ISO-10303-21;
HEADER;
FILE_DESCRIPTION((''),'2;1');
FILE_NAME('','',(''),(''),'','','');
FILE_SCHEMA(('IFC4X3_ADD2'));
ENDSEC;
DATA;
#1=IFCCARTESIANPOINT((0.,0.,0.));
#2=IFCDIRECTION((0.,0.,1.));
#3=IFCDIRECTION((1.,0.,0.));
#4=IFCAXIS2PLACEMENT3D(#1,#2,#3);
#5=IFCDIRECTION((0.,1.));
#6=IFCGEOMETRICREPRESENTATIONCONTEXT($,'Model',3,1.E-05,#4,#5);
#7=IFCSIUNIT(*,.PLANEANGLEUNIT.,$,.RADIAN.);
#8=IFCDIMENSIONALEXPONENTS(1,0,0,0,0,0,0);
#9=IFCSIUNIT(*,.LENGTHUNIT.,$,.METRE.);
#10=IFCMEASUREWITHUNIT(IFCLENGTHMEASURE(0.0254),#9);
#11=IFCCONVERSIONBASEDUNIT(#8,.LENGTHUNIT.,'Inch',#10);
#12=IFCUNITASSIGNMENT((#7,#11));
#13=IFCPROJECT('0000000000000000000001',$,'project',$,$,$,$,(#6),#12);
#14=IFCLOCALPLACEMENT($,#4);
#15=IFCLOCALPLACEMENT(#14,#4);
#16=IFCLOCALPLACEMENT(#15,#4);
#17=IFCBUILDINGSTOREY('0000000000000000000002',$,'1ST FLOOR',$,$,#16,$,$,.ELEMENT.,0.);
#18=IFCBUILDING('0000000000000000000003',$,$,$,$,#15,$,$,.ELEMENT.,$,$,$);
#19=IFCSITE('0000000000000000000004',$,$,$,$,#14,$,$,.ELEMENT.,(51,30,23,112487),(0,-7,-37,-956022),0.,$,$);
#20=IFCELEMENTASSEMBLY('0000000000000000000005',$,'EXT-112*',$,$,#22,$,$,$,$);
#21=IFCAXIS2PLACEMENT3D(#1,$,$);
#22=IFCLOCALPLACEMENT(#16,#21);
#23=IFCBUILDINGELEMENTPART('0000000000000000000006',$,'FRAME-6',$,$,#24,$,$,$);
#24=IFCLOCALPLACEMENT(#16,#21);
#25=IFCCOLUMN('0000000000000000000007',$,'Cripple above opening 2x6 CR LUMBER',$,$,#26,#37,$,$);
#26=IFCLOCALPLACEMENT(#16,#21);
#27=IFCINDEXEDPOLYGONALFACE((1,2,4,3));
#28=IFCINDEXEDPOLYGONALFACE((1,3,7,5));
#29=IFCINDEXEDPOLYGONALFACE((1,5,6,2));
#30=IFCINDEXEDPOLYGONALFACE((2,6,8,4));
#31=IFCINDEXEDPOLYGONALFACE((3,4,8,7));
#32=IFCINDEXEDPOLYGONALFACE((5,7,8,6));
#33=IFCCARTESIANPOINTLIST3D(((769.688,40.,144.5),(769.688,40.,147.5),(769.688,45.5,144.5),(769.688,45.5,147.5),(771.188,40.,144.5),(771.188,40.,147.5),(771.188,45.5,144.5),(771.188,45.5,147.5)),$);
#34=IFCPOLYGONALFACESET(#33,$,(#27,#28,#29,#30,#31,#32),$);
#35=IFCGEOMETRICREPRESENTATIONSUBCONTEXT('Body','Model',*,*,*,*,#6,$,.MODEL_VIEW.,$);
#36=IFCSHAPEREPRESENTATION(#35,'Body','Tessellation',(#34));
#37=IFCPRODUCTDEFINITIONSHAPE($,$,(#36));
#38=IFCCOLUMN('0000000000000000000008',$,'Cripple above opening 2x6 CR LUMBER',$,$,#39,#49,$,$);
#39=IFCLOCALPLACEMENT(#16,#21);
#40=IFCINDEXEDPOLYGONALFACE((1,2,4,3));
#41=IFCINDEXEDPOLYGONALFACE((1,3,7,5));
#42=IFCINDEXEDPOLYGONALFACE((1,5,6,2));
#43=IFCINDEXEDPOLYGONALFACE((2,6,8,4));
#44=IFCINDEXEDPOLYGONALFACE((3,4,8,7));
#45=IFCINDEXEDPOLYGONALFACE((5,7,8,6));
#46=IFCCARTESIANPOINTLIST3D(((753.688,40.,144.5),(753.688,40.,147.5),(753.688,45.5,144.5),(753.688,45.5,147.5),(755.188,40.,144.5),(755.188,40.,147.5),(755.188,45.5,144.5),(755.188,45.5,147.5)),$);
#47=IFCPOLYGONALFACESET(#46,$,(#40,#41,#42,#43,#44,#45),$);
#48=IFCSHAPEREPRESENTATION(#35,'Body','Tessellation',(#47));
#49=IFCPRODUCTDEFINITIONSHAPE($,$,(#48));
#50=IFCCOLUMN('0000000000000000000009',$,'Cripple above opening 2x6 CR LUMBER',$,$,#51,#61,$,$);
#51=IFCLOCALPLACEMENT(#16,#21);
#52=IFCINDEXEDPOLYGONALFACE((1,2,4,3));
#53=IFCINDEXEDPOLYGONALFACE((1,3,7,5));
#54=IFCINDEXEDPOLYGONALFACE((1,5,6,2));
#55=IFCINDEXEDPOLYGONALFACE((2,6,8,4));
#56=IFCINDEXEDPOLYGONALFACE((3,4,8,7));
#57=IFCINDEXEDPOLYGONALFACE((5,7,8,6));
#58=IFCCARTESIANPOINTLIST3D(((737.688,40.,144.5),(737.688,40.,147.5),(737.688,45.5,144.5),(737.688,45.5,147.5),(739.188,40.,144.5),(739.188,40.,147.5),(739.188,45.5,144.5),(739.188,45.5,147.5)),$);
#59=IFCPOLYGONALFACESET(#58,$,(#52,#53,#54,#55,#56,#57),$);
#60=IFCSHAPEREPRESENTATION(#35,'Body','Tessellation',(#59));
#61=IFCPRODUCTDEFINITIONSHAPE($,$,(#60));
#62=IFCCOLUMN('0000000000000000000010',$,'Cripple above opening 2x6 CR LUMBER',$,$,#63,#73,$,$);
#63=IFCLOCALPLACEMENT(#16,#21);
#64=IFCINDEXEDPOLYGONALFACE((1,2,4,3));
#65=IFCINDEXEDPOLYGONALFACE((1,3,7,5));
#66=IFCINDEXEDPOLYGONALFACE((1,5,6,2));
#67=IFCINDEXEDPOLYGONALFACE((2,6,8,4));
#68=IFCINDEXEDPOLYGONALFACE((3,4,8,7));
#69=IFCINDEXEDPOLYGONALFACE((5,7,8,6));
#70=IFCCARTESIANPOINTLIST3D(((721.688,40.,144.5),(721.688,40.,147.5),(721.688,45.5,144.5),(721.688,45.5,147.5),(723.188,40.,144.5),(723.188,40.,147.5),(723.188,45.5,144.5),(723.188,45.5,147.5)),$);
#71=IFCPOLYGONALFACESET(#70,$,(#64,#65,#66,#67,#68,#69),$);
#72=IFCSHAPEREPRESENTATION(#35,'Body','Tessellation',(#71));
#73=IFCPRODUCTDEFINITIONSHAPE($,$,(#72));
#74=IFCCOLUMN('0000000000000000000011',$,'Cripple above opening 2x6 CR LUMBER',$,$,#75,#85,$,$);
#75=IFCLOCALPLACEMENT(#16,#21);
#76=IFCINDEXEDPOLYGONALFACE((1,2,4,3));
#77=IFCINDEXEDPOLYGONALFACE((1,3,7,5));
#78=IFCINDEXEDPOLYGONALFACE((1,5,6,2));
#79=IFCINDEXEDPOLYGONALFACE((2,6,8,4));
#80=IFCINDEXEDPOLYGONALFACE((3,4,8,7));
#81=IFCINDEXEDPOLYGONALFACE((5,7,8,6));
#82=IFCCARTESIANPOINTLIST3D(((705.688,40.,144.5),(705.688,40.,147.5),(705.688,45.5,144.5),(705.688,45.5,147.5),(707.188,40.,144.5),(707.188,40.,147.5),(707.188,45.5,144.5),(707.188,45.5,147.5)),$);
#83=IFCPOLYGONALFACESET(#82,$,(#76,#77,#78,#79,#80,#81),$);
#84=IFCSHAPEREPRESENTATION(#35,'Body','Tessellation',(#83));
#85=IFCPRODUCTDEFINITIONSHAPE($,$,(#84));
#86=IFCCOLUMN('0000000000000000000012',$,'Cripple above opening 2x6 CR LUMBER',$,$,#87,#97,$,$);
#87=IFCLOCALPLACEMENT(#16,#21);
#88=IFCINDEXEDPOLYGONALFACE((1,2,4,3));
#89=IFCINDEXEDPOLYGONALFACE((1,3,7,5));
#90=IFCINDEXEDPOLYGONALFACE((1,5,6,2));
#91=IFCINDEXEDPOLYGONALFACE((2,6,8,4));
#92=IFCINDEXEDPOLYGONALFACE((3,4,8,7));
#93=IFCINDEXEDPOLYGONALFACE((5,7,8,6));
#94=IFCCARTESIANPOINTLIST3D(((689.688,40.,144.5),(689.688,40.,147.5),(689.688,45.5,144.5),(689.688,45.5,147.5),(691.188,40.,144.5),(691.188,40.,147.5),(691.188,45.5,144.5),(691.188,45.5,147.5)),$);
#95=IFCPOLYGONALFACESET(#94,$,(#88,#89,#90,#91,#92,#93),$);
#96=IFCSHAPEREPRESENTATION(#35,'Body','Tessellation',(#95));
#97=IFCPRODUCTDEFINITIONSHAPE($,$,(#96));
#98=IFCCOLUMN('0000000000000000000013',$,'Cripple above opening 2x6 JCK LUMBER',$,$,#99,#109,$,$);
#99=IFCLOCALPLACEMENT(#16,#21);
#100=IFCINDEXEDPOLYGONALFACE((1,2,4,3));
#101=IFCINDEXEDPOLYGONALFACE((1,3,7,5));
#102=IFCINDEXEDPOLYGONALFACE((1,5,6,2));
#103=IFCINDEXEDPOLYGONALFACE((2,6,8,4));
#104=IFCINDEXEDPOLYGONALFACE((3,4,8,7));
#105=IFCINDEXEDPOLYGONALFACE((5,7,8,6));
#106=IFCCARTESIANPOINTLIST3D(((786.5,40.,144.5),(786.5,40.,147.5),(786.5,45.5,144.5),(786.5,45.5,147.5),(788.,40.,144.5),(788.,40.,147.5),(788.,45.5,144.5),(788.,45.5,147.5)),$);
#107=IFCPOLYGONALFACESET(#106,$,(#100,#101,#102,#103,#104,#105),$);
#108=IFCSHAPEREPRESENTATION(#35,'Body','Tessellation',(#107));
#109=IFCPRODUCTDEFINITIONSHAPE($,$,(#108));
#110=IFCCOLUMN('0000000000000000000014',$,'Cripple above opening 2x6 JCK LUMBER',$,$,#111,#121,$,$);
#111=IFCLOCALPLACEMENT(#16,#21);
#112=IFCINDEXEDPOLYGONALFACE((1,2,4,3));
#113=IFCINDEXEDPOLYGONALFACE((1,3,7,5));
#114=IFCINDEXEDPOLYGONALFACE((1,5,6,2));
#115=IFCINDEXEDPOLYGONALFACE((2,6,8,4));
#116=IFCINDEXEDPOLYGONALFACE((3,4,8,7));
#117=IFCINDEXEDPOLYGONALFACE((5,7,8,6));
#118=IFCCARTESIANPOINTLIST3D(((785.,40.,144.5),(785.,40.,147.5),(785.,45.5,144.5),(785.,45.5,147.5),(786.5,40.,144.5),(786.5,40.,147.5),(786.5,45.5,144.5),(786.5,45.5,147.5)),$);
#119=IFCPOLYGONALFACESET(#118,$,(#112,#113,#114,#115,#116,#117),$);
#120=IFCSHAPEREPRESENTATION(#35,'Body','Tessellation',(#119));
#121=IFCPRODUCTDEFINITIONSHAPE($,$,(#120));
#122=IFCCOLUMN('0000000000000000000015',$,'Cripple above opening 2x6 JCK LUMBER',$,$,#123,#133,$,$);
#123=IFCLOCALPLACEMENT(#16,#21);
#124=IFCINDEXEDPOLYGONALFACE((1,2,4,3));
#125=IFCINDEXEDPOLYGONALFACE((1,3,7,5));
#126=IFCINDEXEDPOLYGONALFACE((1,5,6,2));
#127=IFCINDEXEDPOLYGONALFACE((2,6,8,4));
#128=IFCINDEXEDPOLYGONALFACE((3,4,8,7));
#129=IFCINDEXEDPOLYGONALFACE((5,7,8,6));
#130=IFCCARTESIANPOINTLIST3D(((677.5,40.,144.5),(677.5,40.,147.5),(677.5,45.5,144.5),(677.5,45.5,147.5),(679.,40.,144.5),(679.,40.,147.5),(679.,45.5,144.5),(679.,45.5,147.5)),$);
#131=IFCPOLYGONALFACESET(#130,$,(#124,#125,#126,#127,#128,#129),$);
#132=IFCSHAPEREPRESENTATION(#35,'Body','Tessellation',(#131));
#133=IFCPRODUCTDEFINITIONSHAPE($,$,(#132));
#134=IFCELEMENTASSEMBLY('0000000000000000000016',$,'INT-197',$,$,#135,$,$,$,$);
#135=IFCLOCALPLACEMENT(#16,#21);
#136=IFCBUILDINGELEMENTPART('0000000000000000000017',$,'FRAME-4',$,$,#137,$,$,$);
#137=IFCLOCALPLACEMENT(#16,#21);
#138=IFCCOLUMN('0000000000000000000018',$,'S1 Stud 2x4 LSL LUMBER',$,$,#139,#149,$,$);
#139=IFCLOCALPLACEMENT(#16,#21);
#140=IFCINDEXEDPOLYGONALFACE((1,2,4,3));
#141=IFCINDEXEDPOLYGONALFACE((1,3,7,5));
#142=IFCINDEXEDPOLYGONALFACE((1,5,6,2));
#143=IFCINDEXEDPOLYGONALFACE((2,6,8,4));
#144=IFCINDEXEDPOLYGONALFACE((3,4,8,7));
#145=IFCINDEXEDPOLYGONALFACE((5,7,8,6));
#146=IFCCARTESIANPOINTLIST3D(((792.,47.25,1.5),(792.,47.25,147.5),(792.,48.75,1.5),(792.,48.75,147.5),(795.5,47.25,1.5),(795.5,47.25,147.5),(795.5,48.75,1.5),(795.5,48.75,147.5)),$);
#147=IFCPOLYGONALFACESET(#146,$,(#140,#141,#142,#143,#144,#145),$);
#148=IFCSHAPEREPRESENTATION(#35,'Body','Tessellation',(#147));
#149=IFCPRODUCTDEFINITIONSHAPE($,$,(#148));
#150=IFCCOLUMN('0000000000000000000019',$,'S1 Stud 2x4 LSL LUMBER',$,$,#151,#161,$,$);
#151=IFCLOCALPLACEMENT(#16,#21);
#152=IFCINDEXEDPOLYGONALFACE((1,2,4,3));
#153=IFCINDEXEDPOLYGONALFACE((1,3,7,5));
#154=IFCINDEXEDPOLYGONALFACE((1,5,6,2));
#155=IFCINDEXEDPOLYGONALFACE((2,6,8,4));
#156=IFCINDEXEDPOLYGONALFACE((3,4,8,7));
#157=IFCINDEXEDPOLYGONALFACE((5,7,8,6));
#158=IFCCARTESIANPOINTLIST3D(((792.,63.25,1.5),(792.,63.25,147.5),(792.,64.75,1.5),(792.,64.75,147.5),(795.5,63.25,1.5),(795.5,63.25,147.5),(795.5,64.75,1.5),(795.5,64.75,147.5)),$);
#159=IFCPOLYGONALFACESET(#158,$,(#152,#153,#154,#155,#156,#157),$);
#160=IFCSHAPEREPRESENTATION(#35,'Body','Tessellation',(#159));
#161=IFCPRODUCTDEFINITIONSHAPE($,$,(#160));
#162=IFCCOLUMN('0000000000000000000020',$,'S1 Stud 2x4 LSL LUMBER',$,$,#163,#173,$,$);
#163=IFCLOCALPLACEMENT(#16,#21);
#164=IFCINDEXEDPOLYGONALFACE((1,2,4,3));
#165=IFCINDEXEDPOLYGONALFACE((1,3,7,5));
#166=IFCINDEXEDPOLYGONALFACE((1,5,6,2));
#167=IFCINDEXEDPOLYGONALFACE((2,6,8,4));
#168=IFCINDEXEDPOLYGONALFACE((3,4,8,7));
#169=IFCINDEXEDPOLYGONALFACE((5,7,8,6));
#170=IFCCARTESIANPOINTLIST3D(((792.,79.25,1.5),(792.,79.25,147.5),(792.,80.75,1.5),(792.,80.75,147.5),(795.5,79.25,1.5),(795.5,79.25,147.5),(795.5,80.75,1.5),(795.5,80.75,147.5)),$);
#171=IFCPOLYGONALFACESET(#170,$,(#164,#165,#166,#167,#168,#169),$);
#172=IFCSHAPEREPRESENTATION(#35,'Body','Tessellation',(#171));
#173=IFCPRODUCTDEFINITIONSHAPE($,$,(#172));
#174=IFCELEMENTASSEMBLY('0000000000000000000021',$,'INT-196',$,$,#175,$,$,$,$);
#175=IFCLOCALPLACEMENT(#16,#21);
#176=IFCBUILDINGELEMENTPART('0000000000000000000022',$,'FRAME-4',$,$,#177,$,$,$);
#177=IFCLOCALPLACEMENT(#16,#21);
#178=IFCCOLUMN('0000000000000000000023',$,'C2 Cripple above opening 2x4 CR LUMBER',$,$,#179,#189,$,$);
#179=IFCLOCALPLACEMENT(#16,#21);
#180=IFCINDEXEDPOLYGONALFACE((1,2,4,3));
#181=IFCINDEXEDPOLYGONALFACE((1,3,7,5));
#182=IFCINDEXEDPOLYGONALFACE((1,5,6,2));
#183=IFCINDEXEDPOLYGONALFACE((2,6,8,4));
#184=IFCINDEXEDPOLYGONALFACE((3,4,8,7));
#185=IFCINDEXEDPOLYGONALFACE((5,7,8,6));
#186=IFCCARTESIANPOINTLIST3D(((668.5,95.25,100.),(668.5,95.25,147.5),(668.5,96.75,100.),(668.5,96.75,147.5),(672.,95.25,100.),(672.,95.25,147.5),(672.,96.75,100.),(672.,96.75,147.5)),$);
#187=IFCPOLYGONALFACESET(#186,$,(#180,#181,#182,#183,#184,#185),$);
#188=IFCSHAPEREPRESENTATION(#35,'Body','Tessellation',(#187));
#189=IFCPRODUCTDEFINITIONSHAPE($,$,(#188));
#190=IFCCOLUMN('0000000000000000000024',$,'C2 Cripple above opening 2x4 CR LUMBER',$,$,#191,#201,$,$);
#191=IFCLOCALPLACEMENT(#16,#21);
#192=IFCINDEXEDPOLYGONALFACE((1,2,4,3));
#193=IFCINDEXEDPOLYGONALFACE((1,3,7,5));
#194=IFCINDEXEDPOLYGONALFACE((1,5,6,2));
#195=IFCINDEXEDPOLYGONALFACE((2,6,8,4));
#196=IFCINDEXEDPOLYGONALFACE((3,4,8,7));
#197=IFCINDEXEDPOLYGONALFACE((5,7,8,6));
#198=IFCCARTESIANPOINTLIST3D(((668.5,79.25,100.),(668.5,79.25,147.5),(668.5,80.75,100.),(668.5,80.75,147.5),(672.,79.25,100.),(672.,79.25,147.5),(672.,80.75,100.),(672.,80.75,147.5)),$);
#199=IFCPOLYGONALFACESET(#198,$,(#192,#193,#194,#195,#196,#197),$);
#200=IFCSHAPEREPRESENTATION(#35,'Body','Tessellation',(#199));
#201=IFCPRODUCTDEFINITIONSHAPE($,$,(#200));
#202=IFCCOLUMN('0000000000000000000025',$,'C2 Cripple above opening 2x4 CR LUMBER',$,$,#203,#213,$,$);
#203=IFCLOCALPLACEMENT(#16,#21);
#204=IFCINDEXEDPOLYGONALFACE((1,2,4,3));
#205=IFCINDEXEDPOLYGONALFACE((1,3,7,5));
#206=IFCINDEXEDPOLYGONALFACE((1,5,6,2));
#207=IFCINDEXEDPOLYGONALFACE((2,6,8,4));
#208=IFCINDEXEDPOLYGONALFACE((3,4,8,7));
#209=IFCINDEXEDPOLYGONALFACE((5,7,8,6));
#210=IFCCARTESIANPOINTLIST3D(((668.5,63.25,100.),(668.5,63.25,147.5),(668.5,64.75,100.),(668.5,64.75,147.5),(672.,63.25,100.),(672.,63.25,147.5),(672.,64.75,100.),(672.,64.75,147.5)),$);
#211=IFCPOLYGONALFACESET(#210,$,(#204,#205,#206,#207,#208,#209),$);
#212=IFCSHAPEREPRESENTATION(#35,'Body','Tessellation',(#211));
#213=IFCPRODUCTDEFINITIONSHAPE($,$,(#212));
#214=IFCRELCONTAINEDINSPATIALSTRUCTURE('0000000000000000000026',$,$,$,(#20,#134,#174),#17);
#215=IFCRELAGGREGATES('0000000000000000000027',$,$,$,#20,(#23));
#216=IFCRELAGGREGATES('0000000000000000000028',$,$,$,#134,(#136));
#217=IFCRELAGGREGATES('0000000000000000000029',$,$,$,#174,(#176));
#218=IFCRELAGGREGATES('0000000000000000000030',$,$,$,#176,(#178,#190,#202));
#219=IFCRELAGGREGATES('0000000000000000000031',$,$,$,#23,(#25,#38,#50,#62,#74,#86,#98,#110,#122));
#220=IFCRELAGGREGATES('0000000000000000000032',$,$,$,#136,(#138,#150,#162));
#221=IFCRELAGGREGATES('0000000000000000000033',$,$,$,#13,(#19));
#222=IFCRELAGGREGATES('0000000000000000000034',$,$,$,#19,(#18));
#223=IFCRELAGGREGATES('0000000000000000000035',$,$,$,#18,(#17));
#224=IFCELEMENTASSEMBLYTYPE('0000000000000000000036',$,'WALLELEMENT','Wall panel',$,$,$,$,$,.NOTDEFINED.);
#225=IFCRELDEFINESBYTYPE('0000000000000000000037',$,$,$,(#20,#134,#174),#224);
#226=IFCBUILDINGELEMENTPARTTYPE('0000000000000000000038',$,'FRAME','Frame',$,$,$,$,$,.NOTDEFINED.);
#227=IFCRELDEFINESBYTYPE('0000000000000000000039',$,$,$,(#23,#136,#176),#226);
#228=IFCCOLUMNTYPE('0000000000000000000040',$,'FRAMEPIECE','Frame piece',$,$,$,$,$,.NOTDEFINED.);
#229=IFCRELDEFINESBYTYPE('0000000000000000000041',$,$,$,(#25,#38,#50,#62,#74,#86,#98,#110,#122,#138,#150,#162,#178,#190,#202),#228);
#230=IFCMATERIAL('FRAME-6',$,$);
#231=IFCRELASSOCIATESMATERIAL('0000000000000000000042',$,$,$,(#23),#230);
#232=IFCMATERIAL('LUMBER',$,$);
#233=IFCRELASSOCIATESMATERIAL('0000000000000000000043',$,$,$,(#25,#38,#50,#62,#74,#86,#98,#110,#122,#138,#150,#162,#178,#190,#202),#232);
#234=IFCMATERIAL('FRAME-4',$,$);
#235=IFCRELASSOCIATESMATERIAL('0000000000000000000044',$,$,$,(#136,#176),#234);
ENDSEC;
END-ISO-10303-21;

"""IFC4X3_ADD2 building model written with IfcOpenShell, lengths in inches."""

from ifc_helpers import new_model, entity, si_unit, converted_unit, direction, frame, origin_with_axes, origin_2d_with_axis, place, context, subcontext, project, spatial, rectangle, extrude, material, type_object, element, aggregate, save


model = new_model("IFC4X3_ADD2")

# Units and contexts
model_context = context("Model", 3, precision=1e-05, world=origin_with_axes(), true_north=direction((0.0, 1.0)))
body_context = subcontext(model_context, "Body", "Model", "MODEL_VIEW")
ifc_project = project(units=[si_unit("PLANEANGLEUNIT", "RADIAN"), converted_unit("LENGTHUNIT", "Inch", entity("IfcLengthMeasure", 0.0254), si_unit("LENGTHUNIT", "METRE"), dimensions=[1, 0, 0, 0, 0, 0, 0])], contexts=[model_context])

# Site, building, storey
site_placement = place(None, origin_with_axes())
site = spatial("IfcSite", under=ifc_project, at=site_placement, CompositionType="ELEMENT", RefLatitude=(51, 30, 23, 112487), RefLongitude=(0, -7, -37, -956022), RefElevation=0.0)
building_placement = place(site_placement, origin_with_axes())
building = spatial("IfcBuilding", under=site, at=building_placement, CompositionType="ELEMENT")
storey_placement = place(building_placement, origin_with_axes())
storey = spatial("IfcBuildingStorey", under=building, at=storey_placement, Name="1ST FLOOR", CompositionType="ELEMENT", Elevation=0.0)

# Element assemblies, building element parts, columns
element_assembly_type = type_object("IfcElementAssemblyType", Name="WALLELEMENT", Description="Wall panel", PredefinedType="NOTDEFINED")
assembly_1_placement = place(storey_placement, origin_with_axes())
assembly_1 = element("IfcElementAssembly", 1, at=assembly_1_placement, inside=storey, type_object=element_assembly_type, Name="EXT-112*")
ifc_material_1 = material(Name="FRAME-6")
building_element_part_type = type_object("IfcBuildingElementPartType", Name="FRAME", Description="Frame", PredefinedType="NOTDEFINED")
building_element_part_1_placement = place(storey_placement, origin_with_axes())
building_element_part_1 = element("IfcBuildingElementPart", 2, at=building_element_part_1_placement, type_object=building_element_part_type, material=ifc_material_1, Name="FRAME-6")
aggregate(assembly_1, [building_element_part_1])
ifc_material_2 = material(Name="LUMBER")
column_type = type_object("IfcColumnType", Name="FRAMEPIECE", Description="Frame piece", PredefinedType="NOTDEFINED")
column_1_placement = place(storey_placement, frame((770.438, 42.75, 147.5), z_axis=(0.0, 0.0, -1.0), x_axis=(1.0, 0.0, 0.0)))
column_1 = element("IfcColumn", 3, at=column_1_placement, type_object=column_type, material=ifc_material_2, Name="Cripple above opening 2x6 CR LUMBER", context=body_context, shape_type="SweptSolid", body=[
    extrude(rectangle(XDim=1.5, YDim=5.5, at=origin_2d_with_axis()), origin_with_axes(), (0.0, 0.0, 1.0), 3.0),
])
column_2_placement = place(storey_placement, frame((754.438, 42.75, 147.5), z_axis=(0.0, 0.0, -1.0), x_axis=(1.0, 0.0, 0.0)))
column_2 = element("IfcColumn", 4, at=column_2_placement, type_object=column_type, material=ifc_material_2, Name="Cripple above opening 2x6 CR LUMBER", context=body_context, shape_type="SweptSolid", body=[
    extrude(rectangle(XDim=1.5, YDim=5.5, at=origin_2d_with_axis()), origin_with_axes(), (0.0, 0.0, 1.0), 3.0),
])
column_3_placement = place(storey_placement, frame((738.438, 42.75, 147.5), z_axis=(0.0, 0.0, -1.0), x_axis=(1.0, 0.0, 0.0)))
column_3 = element("IfcColumn", 5, at=column_3_placement, type_object=column_type, material=ifc_material_2, Name="Cripple above opening 2x6 CR LUMBER", context=body_context, shape_type="SweptSolid", body=[
    extrude(rectangle(XDim=1.5, YDim=5.5, at=origin_2d_with_axis()), origin_with_axes(), (0.0, 0.0, 1.0), 3.0),
])
column_4_placement = place(storey_placement, frame((722.438, 42.75, 147.5), z_axis=(0.0, 0.0, -1.0), x_axis=(1.0, 0.0, 0.0)))
column_4 = element("IfcColumn", 6, at=column_4_placement, type_object=column_type, material=ifc_material_2, Name="Cripple above opening 2x6 CR LUMBER", context=body_context, shape_type="SweptSolid", body=[
    extrude(rectangle(XDim=1.5, YDim=5.5, at=origin_2d_with_axis()), origin_with_axes(), (0.0, 0.0, 1.0), 3.0),
])
column_5_placement = place(storey_placement, frame((706.438, 42.75, 147.5), z_axis=(0.0, 0.0, -1.0), x_axis=(1.0, 0.0, 0.0)))
column_5 = element("IfcColumn", 7, at=column_5_placement, type_object=column_type, material=ifc_material_2, Name="Cripple above opening 2x6 CR LUMBER", context=body_context, shape_type="SweptSolid", body=[
    extrude(rectangle(XDim=1.5, YDim=5.5, at=origin_2d_with_axis()), origin_with_axes(), (0.0, 0.0, 1.0), 3.0),
])
column_6_placement = place(storey_placement, frame((690.438, 42.75, 147.5), z_axis=(0.0, 0.0, -1.0), x_axis=(1.0, 0.0, 0.0)))
column_6 = element("IfcColumn", 8, at=column_6_placement, type_object=column_type, material=ifc_material_2, Name="Cripple above opening 2x6 CR LUMBER", context=body_context, shape_type="SweptSolid", body=[
    extrude(rectangle(XDim=1.5, YDim=5.5, at=origin_2d_with_axis()), origin_with_axes(), (0.0, 0.0, 1.0), 3.0),
])
column_7_placement = place(storey_placement, frame((787.25, 42.75, 144.5), z_axis=(0.0, 0.0, 1.0), x_axis=(-1.0, 0.0, 0.0)))
column_7 = element("IfcColumn", 9, at=column_7_placement, type_object=column_type, material=ifc_material_2, Name="Cripple above opening 2x6 JCK LUMBER", context=body_context, shape_type="SweptSolid", body=[
    extrude(rectangle(XDim=1.5, YDim=5.5, at=origin_2d_with_axis()), origin_with_axes(), (0.0, 0.0, 1.0), 3.0),
])
column_8_placement = place(storey_placement, frame((785.75, 42.75, 144.5), z_axis=(0.0, 0.0, 1.0), x_axis=(-1.0, 0.0, 0.0)))
column_8 = element("IfcColumn", 10, at=column_8_placement, type_object=column_type, material=ifc_material_2, Name="Cripple above opening 2x6 JCK LUMBER", context=body_context, shape_type="SweptSolid", body=[
    extrude(rectangle(XDim=1.5, YDim=5.5, at=origin_2d_with_axis()), origin_with_axes(), (0.0, 0.0, 1.0), 3.0),
])
column_9_placement = place(storey_placement, frame((678.25, 42.75, 147.5), z_axis=(0.0, 0.0, -1.0), x_axis=(1.0, 0.0, 0.0)))
column_9 = element("IfcColumn", 11, at=column_9_placement, type_object=column_type, material=ifc_material_2, Name="Cripple above opening 2x6 JCK LUMBER", context=body_context, shape_type="SweptSolid", body=[
    extrude(rectangle(XDim=1.5, YDim=5.5, at=origin_2d_with_axis()), origin_with_axes(), (0.0, 0.0, 1.0), 3.0),
])
assembly_2_placement = place(storey_placement, origin_with_axes())
assembly_2 = element("IfcElementAssembly", 12, at=assembly_2_placement, inside=storey, type_object=element_assembly_type, Name="INT-197")
ifc_material_3 = material(Name="FRAME-4")
building_element_part_2_placement = place(storey_placement, origin_with_axes())
building_element_part_2 = element("IfcBuildingElementPart", 13, at=building_element_part_2_placement, type_object=building_element_part_type, material=ifc_material_3, Name="FRAME-4")
aggregate(assembly_2, [building_element_part_2])
column_10_placement = place(storey_placement, frame((793.75, 48.0, 147.5), z_axis=(0.0, 0.0, -1.0), x_axis=(0.0, -1.0, 0.0)))
column_10 = element("IfcColumn", 14, at=column_10_placement, type_object=column_type, material=ifc_material_2, Name="S1 Stud 2x4 LSL LUMBER", context=body_context, shape_type="SweptSolid", body=[
    extrude(rectangle(XDim=1.5, YDim=3.5, at=origin_2d_with_axis()), origin_with_axes(), (0.0, 0.0, 1.0), 146.0),
])
column_11_placement = place(storey_placement, frame((793.75, 64.0, 147.5), z_axis=(0.0, 0.0, -1.0), x_axis=(0.0, -1.0, 0.0)))
column_11 = element("IfcColumn", 15, at=column_11_placement, type_object=column_type, material=ifc_material_2, Name="S1 Stud 2x4 LSL LUMBER", context=body_context, shape_type="SweptSolid", body=[
    extrude(rectangle(XDim=1.5, YDim=3.5, at=origin_2d_with_axis()), origin_with_axes(), (0.0, 0.0, 1.0), 146.0),
])
column_12_placement = place(storey_placement, frame((793.75, 80.0, 147.5), z_axis=(0.0, 0.0, -1.0), x_axis=(0.0, -1.0, 0.0)))
column_12 = element("IfcColumn", 16, at=column_12_placement, type_object=column_type, material=ifc_material_2, Name="S1 Stud 2x4 LSL LUMBER", context=body_context, shape_type="SweptSolid", body=[
    extrude(rectangle(XDim=1.5, YDim=3.5, at=origin_2d_with_axis()), origin_with_axes(), (0.0, 0.0, 1.0), 146.0),
])
assembly_3_placement = place(storey_placement, origin_with_axes())
assembly_3 = element("IfcElementAssembly", 17, at=assembly_3_placement, inside=storey, type_object=element_assembly_type, Name="INT-196")
building_element_part_3_placement = place(storey_placement, origin_with_axes())
building_element_part_3 = element("IfcBuildingElementPart", 18, at=building_element_part_3_placement, type_object=building_element_part_type, material=ifc_material_3, Name="FRAME-4")
aggregate(assembly_3, [building_element_part_3])
column_13_placement = place(storey_placement, frame((670.25, 96.0, 147.5), z_axis=(0.0, 0.0, -1.0), x_axis=(0.0, 1.0, 0.0)))
column_13 = element("IfcColumn", 19, at=column_13_placement, type_object=column_type, material=ifc_material_2, Name="C2 Cripple above opening 2x4 CR LUMBER", context=body_context, shape_type="SweptSolid", body=[
    extrude(rectangle(XDim=1.5, YDim=3.5, at=origin_2d_with_axis()), origin_with_axes(), (0.0, 0.0, 1.0), 47.5),
])
column_14_placement = place(storey_placement, frame((670.25, 80.0, 147.5), z_axis=(0.0, 0.0, -1.0), x_axis=(0.0, 1.0, 0.0)))
column_14 = element("IfcColumn", 20, at=column_14_placement, type_object=column_type, material=ifc_material_2, Name="C2 Cripple above opening 2x4 CR LUMBER", context=body_context, shape_type="SweptSolid", body=[
    extrude(rectangle(XDim=1.5, YDim=3.5, at=origin_2d_with_axis()), origin_with_axes(), (0.0, 0.0, 1.0), 47.5),
])
column_15_placement = place(storey_placement, frame((670.25, 64.0, 147.5), z_axis=(0.0, 0.0, -1.0), x_axis=(0.0, 1.0, 0.0)))
column_15 = element("IfcColumn", 21, at=column_15_placement, type_object=column_type, material=ifc_material_2, Name="C2 Cripple above opening 2x4 CR LUMBER", context=body_context, shape_type="SweptSolid", body=[
    extrude(rectangle(XDim=1.5, YDim=3.5, at=origin_2d_with_axis()), origin_with_axes(), (0.0, 0.0, 1.0), 47.5),
])
aggregate(building_element_part_3, [column_13, column_14, column_15])

aggregate(building_element_part_1, [column_1, column_2, column_3, column_4, column_5, column_6, column_7, column_8, column_9])
aggregate(building_element_part_2, [column_10, column_11, column_12])

save(model, "model.ifc")
